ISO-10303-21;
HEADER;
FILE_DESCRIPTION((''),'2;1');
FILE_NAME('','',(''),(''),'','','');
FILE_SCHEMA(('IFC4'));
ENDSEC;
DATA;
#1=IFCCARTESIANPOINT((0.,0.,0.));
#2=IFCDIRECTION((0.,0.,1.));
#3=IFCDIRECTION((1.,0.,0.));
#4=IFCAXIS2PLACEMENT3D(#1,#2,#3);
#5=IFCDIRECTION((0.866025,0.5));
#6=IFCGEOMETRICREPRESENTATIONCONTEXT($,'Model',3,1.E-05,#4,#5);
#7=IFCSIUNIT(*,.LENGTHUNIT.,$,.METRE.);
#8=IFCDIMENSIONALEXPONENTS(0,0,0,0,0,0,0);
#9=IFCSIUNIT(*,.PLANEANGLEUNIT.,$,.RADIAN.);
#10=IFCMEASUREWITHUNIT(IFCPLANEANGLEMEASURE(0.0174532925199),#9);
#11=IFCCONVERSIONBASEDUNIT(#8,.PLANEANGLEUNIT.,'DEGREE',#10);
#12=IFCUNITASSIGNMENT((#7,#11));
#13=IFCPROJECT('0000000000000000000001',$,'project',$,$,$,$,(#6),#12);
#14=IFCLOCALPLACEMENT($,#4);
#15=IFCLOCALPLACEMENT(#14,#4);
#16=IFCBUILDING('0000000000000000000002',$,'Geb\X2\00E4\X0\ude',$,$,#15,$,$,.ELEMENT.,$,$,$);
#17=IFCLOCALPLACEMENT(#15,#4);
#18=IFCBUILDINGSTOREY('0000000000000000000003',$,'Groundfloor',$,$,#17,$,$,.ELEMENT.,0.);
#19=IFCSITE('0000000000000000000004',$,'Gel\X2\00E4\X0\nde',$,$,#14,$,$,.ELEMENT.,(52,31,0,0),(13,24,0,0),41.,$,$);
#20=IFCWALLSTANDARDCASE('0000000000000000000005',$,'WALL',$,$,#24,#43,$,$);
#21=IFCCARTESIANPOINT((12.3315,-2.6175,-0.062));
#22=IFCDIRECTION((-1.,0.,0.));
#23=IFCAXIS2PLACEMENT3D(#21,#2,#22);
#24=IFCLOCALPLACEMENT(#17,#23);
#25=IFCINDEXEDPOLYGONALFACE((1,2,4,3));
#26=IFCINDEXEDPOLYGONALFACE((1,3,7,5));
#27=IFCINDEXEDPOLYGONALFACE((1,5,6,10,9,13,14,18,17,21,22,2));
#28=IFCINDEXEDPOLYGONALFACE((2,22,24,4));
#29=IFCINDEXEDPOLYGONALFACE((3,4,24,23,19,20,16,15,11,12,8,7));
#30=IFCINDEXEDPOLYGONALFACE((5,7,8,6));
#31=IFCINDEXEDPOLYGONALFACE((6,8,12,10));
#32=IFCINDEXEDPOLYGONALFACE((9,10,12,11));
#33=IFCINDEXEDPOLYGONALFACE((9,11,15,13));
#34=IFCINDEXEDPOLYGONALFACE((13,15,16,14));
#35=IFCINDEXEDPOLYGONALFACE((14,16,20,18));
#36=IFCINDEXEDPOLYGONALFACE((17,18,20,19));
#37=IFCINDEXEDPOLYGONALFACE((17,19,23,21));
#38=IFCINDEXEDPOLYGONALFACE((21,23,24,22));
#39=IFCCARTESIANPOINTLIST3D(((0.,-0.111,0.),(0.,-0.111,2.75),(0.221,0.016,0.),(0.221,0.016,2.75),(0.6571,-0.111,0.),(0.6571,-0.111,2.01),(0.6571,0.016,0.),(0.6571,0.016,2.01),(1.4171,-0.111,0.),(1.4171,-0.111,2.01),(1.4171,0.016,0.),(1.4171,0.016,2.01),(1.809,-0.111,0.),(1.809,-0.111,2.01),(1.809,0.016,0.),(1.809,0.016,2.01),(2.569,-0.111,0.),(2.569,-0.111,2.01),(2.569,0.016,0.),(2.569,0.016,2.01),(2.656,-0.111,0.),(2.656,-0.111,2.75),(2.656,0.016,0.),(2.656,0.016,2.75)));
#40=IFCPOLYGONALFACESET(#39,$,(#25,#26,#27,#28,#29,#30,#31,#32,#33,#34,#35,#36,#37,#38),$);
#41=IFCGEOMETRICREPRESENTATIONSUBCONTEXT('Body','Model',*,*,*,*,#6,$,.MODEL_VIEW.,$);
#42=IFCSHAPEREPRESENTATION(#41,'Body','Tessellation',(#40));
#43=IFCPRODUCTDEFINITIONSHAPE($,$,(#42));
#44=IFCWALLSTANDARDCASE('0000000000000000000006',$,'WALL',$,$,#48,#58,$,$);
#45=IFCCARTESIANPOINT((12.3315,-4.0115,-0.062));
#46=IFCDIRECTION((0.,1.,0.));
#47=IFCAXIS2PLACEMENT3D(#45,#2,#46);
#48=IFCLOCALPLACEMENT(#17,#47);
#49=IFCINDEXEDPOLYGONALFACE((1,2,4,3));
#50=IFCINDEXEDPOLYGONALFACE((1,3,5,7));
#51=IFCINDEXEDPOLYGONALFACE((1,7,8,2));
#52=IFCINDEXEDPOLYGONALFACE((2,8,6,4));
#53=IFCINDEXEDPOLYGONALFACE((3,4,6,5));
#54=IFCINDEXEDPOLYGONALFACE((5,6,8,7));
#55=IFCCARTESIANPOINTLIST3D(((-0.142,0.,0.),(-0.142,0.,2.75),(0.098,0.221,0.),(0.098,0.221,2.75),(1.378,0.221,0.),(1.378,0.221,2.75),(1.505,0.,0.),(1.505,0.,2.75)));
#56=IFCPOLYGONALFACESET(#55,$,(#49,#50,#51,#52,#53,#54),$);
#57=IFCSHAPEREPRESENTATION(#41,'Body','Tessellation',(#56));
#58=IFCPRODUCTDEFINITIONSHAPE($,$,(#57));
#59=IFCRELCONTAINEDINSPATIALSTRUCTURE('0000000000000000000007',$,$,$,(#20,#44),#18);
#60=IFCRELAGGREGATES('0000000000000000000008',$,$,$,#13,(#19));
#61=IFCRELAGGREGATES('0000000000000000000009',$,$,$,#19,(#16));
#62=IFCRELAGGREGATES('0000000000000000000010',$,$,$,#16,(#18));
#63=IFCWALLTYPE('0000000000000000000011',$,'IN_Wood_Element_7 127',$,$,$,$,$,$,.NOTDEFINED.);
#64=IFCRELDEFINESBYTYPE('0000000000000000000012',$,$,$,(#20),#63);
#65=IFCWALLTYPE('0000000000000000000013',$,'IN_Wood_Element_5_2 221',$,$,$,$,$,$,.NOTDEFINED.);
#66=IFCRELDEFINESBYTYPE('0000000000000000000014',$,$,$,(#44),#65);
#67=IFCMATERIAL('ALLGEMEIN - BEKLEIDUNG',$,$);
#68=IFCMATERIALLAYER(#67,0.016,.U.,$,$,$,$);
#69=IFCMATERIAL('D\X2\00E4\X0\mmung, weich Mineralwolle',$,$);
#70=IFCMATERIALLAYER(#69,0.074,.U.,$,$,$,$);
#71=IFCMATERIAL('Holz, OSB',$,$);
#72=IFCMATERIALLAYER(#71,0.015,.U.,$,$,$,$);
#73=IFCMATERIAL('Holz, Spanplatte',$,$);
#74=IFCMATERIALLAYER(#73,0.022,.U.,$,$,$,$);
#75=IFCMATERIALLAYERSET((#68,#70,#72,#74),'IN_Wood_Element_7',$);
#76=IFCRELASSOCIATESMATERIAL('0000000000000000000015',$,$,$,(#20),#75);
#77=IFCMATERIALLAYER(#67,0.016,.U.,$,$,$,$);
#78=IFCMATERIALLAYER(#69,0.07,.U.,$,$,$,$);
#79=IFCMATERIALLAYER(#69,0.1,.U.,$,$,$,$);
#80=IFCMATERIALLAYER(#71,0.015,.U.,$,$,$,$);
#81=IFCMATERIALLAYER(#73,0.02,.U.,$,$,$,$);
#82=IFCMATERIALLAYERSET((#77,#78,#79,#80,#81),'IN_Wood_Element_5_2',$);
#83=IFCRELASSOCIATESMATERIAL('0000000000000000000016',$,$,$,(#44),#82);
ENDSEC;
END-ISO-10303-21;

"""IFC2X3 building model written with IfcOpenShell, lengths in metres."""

from ifc_helpers import new_model, entity, si_unit, converted_unit, direction, frame, origin_with_axes, origin_2d_with_axis, place, context, subcontext, project, spatial, polyline, rectangle, outline, extrude, material, layer, layer_set, layer_usage, type_object, element, save


model = new_model("IFC2X3")

# Units and contexts
model_context = context("Model", 3, precision=1e-05, world=origin_with_axes(), true_north=direction((0.866025, 0.5)))
body_context = subcontext(model_context, "Body", "Model", "MODEL_VIEW")
ifc_project = project(units=[si_unit("LENGTHUNIT", "METRE"), converted_unit("PLANEANGLEUNIT", "DEGREE", entity("IfcPlaneAngleMeasure", 0.0174532925199), si_unit("PLANEANGLEUNIT", "RADIAN"), dimensions=[0, 0, 0, 0, 0, 0, 0])], contexts=[model_context])

# Site, building, storey
site_placement = place(None, origin_with_axes())
site = spatial("IfcSite", under=ifc_project, at=site_placement, Name="Gelände", CompositionType="ELEMENT", RefLatitude=(52, 31, 0, 0), RefLongitude=(13, 24, 0, 0), RefElevation=41.0)
building_placement = place(site_placement, origin_with_axes())
building = spatial("IfcBuilding", under=site, at=building_placement, Name="Gebäude", CompositionType="ELEMENT")
storey_placement = place(building_placement, origin_with_axes())
storey = spatial("IfcBuildingStorey", under=building, at=storey_placement, Name="Groundfloor", CompositionType="ELEMENT", Elevation=0.0)

# Wall, openings
ifc_material_1 = material(Name="ALLGEMEIN - BEKLEIDUNG")
ifc_layer_1 = layer(ifc_material_1, 0.016, ventilated="UNKNOWN")
ifc_material_2 = material(Name="Dämmung, weich Mineralwolle")
ifc_layer_2 = layer(ifc_material_2, 0.074, ventilated="UNKNOWN")
ifc_material_3 = material(Name="Holz, OSB")
ifc_layer_3 = layer(ifc_material_3, 0.015, ventilated="UNKNOWN")
ifc_material_4 = material(Name="Holz, Spanplatte")
ifc_layer_4 = layer(ifc_material_4, 0.022, ventilated="UNKNOWN")
ifc_layer_set_1 = layer_set([ifc_layer_1, ifc_layer_2, ifc_layer_3, ifc_layer_4], Name="IN_Wood_Element_7")
ifc_layer_usage_1 = layer_usage(ifc_layer_set_1, "AXIS2", "NEGATIVE", 0.016)
wall_type_1 = type_object("IfcWallType", Name="IN_Wood_Element_7 127", PredefinedType="NOTDEFINED")
wall_1_placement = place(storey_placement, frame((12.3315, -2.6175, -0.062), z_axis=(0.0, 0.0, 1.0), x_axis=(-1.0, 0.0, 0.0)))
wall_1 = element("IfcWallStandardCase", 1, at=wall_1_placement, inside=storey, type_object=wall_type_1, material=ifc_layer_usage_1, Name="WALL", context=body_context, shape_type="SweptSolid", body=[
    extrude(outline(polyline([(0.0, -0.111), (2.656, -0.111), (2.656, 0.016), (0.221, 0.016), (0.0, -0.111)])), origin_with_axes(), (0.0, 0.0, 1.0), 2.75),
])
opening_1_placement = place(wall_1_placement, frame((1.0371, 0.0, 0.0), z_axis=(0.0, 0.0, 1.0), x_axis=(1.0, 0.0, 0.0)))
element("IfcOpeningElement", 2, at=opening_1_placement, cuts=wall_1, context=body_context, shape_type="SweptSolid", body=[
    extrude(rectangle(XDim=0.76, YDim=2.01, at=origin_2d_with_axis()), frame((0.0, -0.127, 1.005), z_axis=(0.0, 1.0, 0.0), x_axis=(-1.0, 0.0, 0.0)), (0.0, 0.0, 1.0), 0.381),
])
opening_2_placement = place(wall_1_placement, frame((2.189, 0.0, 0.0), z_axis=(0.0, 0.0, 1.0), x_axis=(1.0, 0.0, 0.0)))
element("IfcOpeningElement", 3, at=opening_2_placement, cuts=wall_1, context=body_context, shape_type="SweptSolid", body=[
    extrude(rectangle(XDim=0.76, YDim=2.01, at=origin_2d_with_axis()), frame((0.0, -0.127, 1.005), z_axis=(0.0, -1.0, 0.0), x_axis=(1.0, 0.0, 0.0)), (0.0, 0.0, -1.0), 0.381),
])

# Wall
ifc_layer_5 = layer(ifc_material_1, 0.016, ventilated="UNKNOWN")
ifc_layer_6 = layer(ifc_material_2, 0.07, ventilated="UNKNOWN")
ifc_layer_7 = layer(ifc_material_2, 0.1, ventilated="UNKNOWN")
ifc_layer_8 = layer(ifc_material_3, 0.015, ventilated="UNKNOWN")
ifc_layer_9 = layer(ifc_material_4, 0.02, ventilated="UNKNOWN")
ifc_layer_set_2 = layer_set([ifc_layer_5, ifc_layer_6, ifc_layer_7, ifc_layer_8, ifc_layer_9], Name="IN_Wood_Element_5_2")
ifc_layer_usage_2 = layer_usage(ifc_layer_set_2, "AXIS2", "NEGATIVE", 0.221)
wall_type_2 = type_object("IfcWallType", Name="IN_Wood_Element_5_2 221", PredefinedType="NOTDEFINED")
wall_2_placement = place(storey_placement, frame((12.3315, -4.0115, -0.062), z_axis=(0.0, 0.0, 1.0), x_axis=(0.0, 1.0, 0.0)))
element("IfcWallStandardCase", 4, at=wall_2_placement, inside=storey, type_object=wall_type_2, material=ifc_layer_usage_2, Name="WALL", context=body_context, shape_type="SweptSolid", body=[
    extrude(outline(polyline([(-0.142, 0.0), (1.505, 0.0), (1.378, 0.221), (0.098, 0.221), (-0.142, 0.0)])), origin_with_axes(), (0.0, 0.0, 1.0), 2.75),
])

save(model, "model.ifc")
